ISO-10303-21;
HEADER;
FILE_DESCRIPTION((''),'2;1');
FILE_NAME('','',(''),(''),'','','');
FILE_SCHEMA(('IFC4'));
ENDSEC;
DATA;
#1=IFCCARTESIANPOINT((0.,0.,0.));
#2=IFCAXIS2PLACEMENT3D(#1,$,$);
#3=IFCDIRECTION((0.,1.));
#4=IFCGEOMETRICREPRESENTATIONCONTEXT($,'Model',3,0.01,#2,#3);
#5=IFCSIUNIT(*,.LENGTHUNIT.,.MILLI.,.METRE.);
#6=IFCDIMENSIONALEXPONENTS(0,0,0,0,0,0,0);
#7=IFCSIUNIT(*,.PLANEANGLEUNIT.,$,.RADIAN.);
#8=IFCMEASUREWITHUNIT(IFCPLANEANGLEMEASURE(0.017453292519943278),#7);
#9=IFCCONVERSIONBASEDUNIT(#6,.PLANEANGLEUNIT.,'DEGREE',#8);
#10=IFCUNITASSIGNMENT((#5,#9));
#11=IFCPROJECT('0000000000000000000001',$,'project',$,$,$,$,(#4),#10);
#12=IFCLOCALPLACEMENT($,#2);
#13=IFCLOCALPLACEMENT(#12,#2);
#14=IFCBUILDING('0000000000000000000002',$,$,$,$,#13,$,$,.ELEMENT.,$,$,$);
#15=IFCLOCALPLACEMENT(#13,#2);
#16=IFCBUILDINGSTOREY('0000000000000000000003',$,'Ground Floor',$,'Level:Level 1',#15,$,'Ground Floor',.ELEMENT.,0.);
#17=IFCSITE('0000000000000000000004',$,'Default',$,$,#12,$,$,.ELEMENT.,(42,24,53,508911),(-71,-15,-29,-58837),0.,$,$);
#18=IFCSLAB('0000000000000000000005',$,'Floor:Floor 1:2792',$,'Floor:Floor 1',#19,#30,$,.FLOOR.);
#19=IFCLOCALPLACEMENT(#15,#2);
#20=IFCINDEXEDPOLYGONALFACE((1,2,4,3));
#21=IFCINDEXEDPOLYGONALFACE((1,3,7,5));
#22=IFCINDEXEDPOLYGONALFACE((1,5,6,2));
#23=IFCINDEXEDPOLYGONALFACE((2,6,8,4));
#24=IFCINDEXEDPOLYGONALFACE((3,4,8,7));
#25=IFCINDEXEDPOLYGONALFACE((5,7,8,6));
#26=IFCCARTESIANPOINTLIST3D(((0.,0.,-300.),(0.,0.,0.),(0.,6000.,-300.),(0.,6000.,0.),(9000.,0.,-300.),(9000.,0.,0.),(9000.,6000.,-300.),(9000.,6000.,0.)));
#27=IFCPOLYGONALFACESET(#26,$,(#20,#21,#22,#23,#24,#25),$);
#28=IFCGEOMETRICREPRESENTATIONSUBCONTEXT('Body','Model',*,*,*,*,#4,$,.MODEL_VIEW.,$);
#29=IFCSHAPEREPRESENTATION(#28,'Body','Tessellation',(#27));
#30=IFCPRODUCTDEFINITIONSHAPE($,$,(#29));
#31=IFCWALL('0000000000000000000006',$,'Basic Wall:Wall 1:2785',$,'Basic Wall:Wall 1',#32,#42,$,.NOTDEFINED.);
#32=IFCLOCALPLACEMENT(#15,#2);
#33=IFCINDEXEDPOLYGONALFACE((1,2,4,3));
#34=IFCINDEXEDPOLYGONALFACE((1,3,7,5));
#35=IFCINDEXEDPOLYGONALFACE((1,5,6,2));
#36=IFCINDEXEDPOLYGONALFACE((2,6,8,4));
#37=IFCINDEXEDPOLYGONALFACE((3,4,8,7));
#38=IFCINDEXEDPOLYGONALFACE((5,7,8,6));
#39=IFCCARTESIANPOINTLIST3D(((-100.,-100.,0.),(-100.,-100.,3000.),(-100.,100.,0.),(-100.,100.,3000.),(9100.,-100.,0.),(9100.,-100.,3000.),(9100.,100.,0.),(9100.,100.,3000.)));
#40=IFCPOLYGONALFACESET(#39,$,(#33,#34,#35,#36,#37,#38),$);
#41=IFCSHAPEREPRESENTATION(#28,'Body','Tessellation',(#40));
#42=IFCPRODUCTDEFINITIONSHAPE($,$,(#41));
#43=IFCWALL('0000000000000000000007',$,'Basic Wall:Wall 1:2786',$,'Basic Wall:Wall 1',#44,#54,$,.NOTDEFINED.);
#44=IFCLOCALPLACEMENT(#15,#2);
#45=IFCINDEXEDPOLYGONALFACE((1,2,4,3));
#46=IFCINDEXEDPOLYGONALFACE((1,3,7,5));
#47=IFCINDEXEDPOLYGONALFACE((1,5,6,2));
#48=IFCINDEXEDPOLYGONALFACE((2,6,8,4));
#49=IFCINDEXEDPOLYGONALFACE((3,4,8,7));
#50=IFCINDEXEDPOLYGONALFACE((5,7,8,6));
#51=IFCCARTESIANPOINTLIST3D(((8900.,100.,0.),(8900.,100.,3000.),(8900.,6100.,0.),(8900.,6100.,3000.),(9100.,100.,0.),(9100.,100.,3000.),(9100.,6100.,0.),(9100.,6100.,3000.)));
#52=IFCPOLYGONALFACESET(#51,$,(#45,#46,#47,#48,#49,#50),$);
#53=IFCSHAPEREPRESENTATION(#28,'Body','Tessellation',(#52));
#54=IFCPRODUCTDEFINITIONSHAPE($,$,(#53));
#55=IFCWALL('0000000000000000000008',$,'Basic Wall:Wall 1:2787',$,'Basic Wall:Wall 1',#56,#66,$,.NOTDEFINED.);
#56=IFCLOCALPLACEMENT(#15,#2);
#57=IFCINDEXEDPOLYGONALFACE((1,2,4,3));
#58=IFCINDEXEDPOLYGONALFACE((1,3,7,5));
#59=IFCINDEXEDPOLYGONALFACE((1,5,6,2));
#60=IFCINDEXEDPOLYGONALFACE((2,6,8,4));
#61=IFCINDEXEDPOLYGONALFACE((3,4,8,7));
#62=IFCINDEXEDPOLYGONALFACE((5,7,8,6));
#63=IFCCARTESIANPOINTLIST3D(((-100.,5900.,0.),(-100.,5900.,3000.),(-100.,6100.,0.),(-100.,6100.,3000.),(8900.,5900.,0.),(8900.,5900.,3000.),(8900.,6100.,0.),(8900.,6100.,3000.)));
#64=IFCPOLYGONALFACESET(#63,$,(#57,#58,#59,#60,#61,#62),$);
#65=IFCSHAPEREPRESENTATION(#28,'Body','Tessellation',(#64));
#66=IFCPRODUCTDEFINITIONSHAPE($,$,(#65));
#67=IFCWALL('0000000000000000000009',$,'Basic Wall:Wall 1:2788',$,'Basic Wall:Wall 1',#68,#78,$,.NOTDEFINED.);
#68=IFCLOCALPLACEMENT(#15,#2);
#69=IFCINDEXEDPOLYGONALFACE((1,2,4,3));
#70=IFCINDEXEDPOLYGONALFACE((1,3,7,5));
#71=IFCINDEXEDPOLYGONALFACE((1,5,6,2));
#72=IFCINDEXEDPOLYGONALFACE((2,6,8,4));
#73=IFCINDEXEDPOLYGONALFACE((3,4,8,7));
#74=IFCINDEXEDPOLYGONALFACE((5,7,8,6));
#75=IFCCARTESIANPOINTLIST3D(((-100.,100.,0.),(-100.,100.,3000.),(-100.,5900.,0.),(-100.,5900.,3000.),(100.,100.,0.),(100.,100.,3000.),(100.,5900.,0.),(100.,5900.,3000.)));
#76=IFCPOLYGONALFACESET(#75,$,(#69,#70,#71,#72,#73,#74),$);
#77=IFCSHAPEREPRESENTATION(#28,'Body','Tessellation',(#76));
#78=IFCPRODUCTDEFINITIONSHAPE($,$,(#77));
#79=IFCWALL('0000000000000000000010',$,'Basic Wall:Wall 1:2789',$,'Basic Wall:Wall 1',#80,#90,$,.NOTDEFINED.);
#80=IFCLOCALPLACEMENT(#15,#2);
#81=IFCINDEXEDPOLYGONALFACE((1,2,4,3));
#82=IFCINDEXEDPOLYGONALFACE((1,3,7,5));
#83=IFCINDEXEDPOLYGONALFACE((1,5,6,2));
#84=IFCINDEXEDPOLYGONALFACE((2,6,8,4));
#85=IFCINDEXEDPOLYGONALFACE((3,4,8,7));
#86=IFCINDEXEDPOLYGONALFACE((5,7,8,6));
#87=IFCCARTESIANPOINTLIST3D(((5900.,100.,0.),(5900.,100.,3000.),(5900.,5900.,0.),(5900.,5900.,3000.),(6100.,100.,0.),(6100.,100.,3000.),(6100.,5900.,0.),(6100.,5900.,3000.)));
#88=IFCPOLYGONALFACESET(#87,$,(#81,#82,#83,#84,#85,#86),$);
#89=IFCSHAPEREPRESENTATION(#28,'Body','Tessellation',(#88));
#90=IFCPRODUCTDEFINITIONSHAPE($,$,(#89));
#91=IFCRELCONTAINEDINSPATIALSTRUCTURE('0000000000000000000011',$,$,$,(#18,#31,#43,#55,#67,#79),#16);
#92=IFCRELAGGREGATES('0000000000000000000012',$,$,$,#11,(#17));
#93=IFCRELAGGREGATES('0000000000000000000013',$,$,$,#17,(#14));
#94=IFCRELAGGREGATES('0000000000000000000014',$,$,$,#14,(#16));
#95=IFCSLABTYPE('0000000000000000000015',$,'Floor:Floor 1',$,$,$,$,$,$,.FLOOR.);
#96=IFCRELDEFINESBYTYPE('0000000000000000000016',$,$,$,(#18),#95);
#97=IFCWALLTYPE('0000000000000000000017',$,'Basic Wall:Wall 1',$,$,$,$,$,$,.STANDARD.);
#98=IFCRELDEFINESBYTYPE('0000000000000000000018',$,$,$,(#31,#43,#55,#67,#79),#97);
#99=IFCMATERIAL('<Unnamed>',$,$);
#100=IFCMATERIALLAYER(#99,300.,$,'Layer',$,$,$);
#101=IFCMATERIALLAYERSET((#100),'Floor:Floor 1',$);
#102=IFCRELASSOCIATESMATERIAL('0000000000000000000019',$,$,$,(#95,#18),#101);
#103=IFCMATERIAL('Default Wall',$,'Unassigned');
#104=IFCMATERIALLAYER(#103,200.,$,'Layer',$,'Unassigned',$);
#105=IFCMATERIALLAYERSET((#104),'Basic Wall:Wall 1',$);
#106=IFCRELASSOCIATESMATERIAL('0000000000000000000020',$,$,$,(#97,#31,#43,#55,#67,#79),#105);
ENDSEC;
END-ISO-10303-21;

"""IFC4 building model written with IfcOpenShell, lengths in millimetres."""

from ifc_helpers import new_model, entity, si_unit, converted_unit, direction, frame, frame_2d, origin, origin_2d_with_axis, place, context, subcontext, project, spatial, rectangle, extrude, material, layer, layer_set, layer_usage, type_object, element, save


model = new_model("IFC4")

# Units and contexts
model_context = context("Model", 3, precision=0.01, world=origin(), true_north=direction((0.0, 1.0)))
body_context = subcontext(model_context, "Body", "Model", "MODEL_VIEW")
ifc_project = project(units=[si_unit("LENGTHUNIT", "METRE", prefix="MILLI"), converted_unit("PLANEANGLEUNIT", "DEGREE", entity("IfcPlaneAngleMeasure", 0.017453292519943278), si_unit("PLANEANGLEUNIT", "RADIAN"), dimensions=[0, 0, 0, 0, 0, 0, 0])], contexts=[model_context])

# Site, building, storey
site_placement = place(None, origin())
site = spatial("IfcSite", under=ifc_project, at=site_placement, Name="Default", CompositionType="ELEMENT", RefLatitude=(42, 24, 53, 508911), RefLongitude=(-71, -15, -29, -58837), RefElevation=0.0)
building_placement = place(site_placement, origin())
building = spatial("IfcBuilding", under=site, at=building_placement, CompositionType="ELEMENT")
storey_placement = place(building_placement, origin())
storey = spatial("IfcBuildingStorey", under=building, at=storey_placement, Name="Ground Floor", ObjectType="Level:Level 1", LongName="Ground Floor", CompositionType="ELEMENT", Elevation=0.0)

# Slab
ifc_material_1 = material(Name="<Unnamed>")
ifc_layer_1 = layer(ifc_material_1, 300.0, Name="Layer")
ifc_layer_set_1 = layer_set([ifc_layer_1], Name="Floor:Floor 1")
ifc_layer_usage_1 = layer_usage(ifc_layer_set_1, "AXIS3", "POSITIVE", 0.0)
slab_type = type_object("IfcSlabType", Name="Floor:Floor 1", PredefinedType="FLOOR", material=ifc_layer_set_1)
slab_placement = place(storey_placement, origin())
element("IfcSlab", 1, at=slab_placement, inside=storey, type_object=slab_type, material=ifc_layer_usage_1, Name="Floor:Floor 1:2792", ObjectType="Floor:Floor 1", PredefinedType="FLOOR", context=body_context, shape_type="SweptSolid", body=[
    extrude(rectangle(XDim=6000.0, YDim=9000.0, at=origin_2d_with_axis()), frame((4500.0, 3000.0, 0.0), z_axis=(0.0, 0.0, -1.0), x_axis=(0.0, 1.0, 0.0)), (0.0, 0.0, 1.0), 300.0),
])

# Walls
ifc_material_2 = material(Name="Default Wall", Category="Unassigned")
ifc_layer_2 = layer(ifc_material_2, 200.0, Name="Layer", Category="Unassigned")
ifc_layer_set_2 = layer_set([ifc_layer_2], Name="Basic Wall:Wall 1")
ifc_layer_usage_2 = layer_usage(ifc_layer_set_2, "AXIS2", "NEGATIVE", 100.0)
wall_type = type_object("IfcWallType", Name="Basic Wall:Wall 1", PredefinedType="STANDARD", material=ifc_layer_set_2)
wall_1_placement = place(storey_placement, frame((-100.0, 0.0, 0.0)))
element("IfcWall", 2, at=wall_1_placement, inside=storey, type_object=wall_type, material=ifc_layer_usage_2, Name="Basic Wall:Wall 1:2785", ObjectType="Basic Wall:Wall 1", PredefinedType="NOTDEFINED", context=body_context, shape_type="SweptSolid", body=[
    extrude(rectangle(XDim=9200.0, YDim=200.0, at=frame_2d((4600.0, 0.0), x_axis=(-1.0, 0.0))), origin(), (0.0, 0.0, 1.0), 3000.0),
])
ifc_layer_usage_3 = layer_usage(ifc_layer_set_2, "AXIS2", "NEGATIVE", 100.0)
wall_2_placement = place(storey_placement, frame((9000.0, 100.0, 0.0), z_axis=(0.0, 0.0, 1.0), x_axis=(0.0, 1.0, 0.0)))
element("IfcWall", 3, at=wall_2_placement, inside=storey, type_object=wall_type, material=ifc_layer_usage_3, Name="Basic Wall:Wall 1:2786", ObjectType="Basic Wall:Wall 1", PredefinedType="NOTDEFINED", context=body_context, shape_type="SweptSolid", body=[
    extrude(rectangle(XDim=6000.0, YDim=200.0, at=frame_2d((3000.0, 0.0), x_axis=(-1.0, 0.0))), origin(), (0.0, 0.0, 1.0), 3000.0),
])
ifc_layer_usage_4 = layer_usage(ifc_layer_set_2, "AXIS2", "NEGATIVE", 100.0)
wall_3_placement = place(storey_placement, frame((8900.0, 6000.0, 0.0), z_axis=(0.0, 0.0, 1.0), x_axis=(-1.0, 0.0, 0.0)))
element("IfcWall", 4, at=wall_3_placement, inside=storey, type_object=wall_type, material=ifc_layer_usage_4, Name="Basic Wall:Wall 1:2787", ObjectType="Basic Wall:Wall 1", PredefinedType="NOTDEFINED", context=body_context, shape_type="SweptSolid", body=[
    extrude(rectangle(XDim=9000.0, YDim=200.0, at=frame_2d((4500.0, 0.0), x_axis=(-1.0, 0.0))), origin(), (0.0, 0.0, 1.0), 3000.0),
])
ifc_layer_usage_5 = layer_usage(ifc_layer_set_2, "AXIS2", "NEGATIVE", 100.0)
wall_4_placement = place(storey_placement, frame((0.0, 5900.0, 0.0), z_axis=(0.0, 0.0, 1.0), x_axis=(0.0, -1.0, 0.0)))
element("IfcWall", 5, at=wall_4_placement, inside=storey, type_object=wall_type, material=ifc_layer_usage_5, Name="Basic Wall:Wall 1:2788", ObjectType="Basic Wall:Wall 1", PredefinedType="NOTDEFINED", context=body_context, shape_type="SweptSolid", body=[
    extrude(rectangle(XDim=5800.0, YDim=200.0, at=frame_2d((2900.0, 0.0), x_axis=(-1.0, 0.0))), origin(), (0.0, 0.0, 1.0), 3000.0),
])
ifc_layer_usage_6 = layer_usage(ifc_layer_set_2, "AXIS2", "NEGATIVE", 100.0)
wall_5_placement = place(storey_placement, frame((6000.0, 100.0, 0.0), z_axis=(0.0, 0.0, 1.0), x_axis=(0.0, 1.0, 0.0)))
element("IfcWall", 6, at=wall_5_placement, inside=storey, type_object=wall_type, material=ifc_layer_usage_6, Name="Basic Wall:Wall 1:2789", ObjectType="Basic Wall:Wall 1", PredefinedType="NOTDEFINED", context=body_context, shape_type="SweptSolid", body=[
    extrude(rectangle(XDim=5800.0, YDim=200.0, at=frame_2d((2900.0, 0.0), x_axis=(-1.0, 0.0))), origin(), (0.0, 0.0, 1.0), 3000.0),
])

save(model, "model.ifc")
